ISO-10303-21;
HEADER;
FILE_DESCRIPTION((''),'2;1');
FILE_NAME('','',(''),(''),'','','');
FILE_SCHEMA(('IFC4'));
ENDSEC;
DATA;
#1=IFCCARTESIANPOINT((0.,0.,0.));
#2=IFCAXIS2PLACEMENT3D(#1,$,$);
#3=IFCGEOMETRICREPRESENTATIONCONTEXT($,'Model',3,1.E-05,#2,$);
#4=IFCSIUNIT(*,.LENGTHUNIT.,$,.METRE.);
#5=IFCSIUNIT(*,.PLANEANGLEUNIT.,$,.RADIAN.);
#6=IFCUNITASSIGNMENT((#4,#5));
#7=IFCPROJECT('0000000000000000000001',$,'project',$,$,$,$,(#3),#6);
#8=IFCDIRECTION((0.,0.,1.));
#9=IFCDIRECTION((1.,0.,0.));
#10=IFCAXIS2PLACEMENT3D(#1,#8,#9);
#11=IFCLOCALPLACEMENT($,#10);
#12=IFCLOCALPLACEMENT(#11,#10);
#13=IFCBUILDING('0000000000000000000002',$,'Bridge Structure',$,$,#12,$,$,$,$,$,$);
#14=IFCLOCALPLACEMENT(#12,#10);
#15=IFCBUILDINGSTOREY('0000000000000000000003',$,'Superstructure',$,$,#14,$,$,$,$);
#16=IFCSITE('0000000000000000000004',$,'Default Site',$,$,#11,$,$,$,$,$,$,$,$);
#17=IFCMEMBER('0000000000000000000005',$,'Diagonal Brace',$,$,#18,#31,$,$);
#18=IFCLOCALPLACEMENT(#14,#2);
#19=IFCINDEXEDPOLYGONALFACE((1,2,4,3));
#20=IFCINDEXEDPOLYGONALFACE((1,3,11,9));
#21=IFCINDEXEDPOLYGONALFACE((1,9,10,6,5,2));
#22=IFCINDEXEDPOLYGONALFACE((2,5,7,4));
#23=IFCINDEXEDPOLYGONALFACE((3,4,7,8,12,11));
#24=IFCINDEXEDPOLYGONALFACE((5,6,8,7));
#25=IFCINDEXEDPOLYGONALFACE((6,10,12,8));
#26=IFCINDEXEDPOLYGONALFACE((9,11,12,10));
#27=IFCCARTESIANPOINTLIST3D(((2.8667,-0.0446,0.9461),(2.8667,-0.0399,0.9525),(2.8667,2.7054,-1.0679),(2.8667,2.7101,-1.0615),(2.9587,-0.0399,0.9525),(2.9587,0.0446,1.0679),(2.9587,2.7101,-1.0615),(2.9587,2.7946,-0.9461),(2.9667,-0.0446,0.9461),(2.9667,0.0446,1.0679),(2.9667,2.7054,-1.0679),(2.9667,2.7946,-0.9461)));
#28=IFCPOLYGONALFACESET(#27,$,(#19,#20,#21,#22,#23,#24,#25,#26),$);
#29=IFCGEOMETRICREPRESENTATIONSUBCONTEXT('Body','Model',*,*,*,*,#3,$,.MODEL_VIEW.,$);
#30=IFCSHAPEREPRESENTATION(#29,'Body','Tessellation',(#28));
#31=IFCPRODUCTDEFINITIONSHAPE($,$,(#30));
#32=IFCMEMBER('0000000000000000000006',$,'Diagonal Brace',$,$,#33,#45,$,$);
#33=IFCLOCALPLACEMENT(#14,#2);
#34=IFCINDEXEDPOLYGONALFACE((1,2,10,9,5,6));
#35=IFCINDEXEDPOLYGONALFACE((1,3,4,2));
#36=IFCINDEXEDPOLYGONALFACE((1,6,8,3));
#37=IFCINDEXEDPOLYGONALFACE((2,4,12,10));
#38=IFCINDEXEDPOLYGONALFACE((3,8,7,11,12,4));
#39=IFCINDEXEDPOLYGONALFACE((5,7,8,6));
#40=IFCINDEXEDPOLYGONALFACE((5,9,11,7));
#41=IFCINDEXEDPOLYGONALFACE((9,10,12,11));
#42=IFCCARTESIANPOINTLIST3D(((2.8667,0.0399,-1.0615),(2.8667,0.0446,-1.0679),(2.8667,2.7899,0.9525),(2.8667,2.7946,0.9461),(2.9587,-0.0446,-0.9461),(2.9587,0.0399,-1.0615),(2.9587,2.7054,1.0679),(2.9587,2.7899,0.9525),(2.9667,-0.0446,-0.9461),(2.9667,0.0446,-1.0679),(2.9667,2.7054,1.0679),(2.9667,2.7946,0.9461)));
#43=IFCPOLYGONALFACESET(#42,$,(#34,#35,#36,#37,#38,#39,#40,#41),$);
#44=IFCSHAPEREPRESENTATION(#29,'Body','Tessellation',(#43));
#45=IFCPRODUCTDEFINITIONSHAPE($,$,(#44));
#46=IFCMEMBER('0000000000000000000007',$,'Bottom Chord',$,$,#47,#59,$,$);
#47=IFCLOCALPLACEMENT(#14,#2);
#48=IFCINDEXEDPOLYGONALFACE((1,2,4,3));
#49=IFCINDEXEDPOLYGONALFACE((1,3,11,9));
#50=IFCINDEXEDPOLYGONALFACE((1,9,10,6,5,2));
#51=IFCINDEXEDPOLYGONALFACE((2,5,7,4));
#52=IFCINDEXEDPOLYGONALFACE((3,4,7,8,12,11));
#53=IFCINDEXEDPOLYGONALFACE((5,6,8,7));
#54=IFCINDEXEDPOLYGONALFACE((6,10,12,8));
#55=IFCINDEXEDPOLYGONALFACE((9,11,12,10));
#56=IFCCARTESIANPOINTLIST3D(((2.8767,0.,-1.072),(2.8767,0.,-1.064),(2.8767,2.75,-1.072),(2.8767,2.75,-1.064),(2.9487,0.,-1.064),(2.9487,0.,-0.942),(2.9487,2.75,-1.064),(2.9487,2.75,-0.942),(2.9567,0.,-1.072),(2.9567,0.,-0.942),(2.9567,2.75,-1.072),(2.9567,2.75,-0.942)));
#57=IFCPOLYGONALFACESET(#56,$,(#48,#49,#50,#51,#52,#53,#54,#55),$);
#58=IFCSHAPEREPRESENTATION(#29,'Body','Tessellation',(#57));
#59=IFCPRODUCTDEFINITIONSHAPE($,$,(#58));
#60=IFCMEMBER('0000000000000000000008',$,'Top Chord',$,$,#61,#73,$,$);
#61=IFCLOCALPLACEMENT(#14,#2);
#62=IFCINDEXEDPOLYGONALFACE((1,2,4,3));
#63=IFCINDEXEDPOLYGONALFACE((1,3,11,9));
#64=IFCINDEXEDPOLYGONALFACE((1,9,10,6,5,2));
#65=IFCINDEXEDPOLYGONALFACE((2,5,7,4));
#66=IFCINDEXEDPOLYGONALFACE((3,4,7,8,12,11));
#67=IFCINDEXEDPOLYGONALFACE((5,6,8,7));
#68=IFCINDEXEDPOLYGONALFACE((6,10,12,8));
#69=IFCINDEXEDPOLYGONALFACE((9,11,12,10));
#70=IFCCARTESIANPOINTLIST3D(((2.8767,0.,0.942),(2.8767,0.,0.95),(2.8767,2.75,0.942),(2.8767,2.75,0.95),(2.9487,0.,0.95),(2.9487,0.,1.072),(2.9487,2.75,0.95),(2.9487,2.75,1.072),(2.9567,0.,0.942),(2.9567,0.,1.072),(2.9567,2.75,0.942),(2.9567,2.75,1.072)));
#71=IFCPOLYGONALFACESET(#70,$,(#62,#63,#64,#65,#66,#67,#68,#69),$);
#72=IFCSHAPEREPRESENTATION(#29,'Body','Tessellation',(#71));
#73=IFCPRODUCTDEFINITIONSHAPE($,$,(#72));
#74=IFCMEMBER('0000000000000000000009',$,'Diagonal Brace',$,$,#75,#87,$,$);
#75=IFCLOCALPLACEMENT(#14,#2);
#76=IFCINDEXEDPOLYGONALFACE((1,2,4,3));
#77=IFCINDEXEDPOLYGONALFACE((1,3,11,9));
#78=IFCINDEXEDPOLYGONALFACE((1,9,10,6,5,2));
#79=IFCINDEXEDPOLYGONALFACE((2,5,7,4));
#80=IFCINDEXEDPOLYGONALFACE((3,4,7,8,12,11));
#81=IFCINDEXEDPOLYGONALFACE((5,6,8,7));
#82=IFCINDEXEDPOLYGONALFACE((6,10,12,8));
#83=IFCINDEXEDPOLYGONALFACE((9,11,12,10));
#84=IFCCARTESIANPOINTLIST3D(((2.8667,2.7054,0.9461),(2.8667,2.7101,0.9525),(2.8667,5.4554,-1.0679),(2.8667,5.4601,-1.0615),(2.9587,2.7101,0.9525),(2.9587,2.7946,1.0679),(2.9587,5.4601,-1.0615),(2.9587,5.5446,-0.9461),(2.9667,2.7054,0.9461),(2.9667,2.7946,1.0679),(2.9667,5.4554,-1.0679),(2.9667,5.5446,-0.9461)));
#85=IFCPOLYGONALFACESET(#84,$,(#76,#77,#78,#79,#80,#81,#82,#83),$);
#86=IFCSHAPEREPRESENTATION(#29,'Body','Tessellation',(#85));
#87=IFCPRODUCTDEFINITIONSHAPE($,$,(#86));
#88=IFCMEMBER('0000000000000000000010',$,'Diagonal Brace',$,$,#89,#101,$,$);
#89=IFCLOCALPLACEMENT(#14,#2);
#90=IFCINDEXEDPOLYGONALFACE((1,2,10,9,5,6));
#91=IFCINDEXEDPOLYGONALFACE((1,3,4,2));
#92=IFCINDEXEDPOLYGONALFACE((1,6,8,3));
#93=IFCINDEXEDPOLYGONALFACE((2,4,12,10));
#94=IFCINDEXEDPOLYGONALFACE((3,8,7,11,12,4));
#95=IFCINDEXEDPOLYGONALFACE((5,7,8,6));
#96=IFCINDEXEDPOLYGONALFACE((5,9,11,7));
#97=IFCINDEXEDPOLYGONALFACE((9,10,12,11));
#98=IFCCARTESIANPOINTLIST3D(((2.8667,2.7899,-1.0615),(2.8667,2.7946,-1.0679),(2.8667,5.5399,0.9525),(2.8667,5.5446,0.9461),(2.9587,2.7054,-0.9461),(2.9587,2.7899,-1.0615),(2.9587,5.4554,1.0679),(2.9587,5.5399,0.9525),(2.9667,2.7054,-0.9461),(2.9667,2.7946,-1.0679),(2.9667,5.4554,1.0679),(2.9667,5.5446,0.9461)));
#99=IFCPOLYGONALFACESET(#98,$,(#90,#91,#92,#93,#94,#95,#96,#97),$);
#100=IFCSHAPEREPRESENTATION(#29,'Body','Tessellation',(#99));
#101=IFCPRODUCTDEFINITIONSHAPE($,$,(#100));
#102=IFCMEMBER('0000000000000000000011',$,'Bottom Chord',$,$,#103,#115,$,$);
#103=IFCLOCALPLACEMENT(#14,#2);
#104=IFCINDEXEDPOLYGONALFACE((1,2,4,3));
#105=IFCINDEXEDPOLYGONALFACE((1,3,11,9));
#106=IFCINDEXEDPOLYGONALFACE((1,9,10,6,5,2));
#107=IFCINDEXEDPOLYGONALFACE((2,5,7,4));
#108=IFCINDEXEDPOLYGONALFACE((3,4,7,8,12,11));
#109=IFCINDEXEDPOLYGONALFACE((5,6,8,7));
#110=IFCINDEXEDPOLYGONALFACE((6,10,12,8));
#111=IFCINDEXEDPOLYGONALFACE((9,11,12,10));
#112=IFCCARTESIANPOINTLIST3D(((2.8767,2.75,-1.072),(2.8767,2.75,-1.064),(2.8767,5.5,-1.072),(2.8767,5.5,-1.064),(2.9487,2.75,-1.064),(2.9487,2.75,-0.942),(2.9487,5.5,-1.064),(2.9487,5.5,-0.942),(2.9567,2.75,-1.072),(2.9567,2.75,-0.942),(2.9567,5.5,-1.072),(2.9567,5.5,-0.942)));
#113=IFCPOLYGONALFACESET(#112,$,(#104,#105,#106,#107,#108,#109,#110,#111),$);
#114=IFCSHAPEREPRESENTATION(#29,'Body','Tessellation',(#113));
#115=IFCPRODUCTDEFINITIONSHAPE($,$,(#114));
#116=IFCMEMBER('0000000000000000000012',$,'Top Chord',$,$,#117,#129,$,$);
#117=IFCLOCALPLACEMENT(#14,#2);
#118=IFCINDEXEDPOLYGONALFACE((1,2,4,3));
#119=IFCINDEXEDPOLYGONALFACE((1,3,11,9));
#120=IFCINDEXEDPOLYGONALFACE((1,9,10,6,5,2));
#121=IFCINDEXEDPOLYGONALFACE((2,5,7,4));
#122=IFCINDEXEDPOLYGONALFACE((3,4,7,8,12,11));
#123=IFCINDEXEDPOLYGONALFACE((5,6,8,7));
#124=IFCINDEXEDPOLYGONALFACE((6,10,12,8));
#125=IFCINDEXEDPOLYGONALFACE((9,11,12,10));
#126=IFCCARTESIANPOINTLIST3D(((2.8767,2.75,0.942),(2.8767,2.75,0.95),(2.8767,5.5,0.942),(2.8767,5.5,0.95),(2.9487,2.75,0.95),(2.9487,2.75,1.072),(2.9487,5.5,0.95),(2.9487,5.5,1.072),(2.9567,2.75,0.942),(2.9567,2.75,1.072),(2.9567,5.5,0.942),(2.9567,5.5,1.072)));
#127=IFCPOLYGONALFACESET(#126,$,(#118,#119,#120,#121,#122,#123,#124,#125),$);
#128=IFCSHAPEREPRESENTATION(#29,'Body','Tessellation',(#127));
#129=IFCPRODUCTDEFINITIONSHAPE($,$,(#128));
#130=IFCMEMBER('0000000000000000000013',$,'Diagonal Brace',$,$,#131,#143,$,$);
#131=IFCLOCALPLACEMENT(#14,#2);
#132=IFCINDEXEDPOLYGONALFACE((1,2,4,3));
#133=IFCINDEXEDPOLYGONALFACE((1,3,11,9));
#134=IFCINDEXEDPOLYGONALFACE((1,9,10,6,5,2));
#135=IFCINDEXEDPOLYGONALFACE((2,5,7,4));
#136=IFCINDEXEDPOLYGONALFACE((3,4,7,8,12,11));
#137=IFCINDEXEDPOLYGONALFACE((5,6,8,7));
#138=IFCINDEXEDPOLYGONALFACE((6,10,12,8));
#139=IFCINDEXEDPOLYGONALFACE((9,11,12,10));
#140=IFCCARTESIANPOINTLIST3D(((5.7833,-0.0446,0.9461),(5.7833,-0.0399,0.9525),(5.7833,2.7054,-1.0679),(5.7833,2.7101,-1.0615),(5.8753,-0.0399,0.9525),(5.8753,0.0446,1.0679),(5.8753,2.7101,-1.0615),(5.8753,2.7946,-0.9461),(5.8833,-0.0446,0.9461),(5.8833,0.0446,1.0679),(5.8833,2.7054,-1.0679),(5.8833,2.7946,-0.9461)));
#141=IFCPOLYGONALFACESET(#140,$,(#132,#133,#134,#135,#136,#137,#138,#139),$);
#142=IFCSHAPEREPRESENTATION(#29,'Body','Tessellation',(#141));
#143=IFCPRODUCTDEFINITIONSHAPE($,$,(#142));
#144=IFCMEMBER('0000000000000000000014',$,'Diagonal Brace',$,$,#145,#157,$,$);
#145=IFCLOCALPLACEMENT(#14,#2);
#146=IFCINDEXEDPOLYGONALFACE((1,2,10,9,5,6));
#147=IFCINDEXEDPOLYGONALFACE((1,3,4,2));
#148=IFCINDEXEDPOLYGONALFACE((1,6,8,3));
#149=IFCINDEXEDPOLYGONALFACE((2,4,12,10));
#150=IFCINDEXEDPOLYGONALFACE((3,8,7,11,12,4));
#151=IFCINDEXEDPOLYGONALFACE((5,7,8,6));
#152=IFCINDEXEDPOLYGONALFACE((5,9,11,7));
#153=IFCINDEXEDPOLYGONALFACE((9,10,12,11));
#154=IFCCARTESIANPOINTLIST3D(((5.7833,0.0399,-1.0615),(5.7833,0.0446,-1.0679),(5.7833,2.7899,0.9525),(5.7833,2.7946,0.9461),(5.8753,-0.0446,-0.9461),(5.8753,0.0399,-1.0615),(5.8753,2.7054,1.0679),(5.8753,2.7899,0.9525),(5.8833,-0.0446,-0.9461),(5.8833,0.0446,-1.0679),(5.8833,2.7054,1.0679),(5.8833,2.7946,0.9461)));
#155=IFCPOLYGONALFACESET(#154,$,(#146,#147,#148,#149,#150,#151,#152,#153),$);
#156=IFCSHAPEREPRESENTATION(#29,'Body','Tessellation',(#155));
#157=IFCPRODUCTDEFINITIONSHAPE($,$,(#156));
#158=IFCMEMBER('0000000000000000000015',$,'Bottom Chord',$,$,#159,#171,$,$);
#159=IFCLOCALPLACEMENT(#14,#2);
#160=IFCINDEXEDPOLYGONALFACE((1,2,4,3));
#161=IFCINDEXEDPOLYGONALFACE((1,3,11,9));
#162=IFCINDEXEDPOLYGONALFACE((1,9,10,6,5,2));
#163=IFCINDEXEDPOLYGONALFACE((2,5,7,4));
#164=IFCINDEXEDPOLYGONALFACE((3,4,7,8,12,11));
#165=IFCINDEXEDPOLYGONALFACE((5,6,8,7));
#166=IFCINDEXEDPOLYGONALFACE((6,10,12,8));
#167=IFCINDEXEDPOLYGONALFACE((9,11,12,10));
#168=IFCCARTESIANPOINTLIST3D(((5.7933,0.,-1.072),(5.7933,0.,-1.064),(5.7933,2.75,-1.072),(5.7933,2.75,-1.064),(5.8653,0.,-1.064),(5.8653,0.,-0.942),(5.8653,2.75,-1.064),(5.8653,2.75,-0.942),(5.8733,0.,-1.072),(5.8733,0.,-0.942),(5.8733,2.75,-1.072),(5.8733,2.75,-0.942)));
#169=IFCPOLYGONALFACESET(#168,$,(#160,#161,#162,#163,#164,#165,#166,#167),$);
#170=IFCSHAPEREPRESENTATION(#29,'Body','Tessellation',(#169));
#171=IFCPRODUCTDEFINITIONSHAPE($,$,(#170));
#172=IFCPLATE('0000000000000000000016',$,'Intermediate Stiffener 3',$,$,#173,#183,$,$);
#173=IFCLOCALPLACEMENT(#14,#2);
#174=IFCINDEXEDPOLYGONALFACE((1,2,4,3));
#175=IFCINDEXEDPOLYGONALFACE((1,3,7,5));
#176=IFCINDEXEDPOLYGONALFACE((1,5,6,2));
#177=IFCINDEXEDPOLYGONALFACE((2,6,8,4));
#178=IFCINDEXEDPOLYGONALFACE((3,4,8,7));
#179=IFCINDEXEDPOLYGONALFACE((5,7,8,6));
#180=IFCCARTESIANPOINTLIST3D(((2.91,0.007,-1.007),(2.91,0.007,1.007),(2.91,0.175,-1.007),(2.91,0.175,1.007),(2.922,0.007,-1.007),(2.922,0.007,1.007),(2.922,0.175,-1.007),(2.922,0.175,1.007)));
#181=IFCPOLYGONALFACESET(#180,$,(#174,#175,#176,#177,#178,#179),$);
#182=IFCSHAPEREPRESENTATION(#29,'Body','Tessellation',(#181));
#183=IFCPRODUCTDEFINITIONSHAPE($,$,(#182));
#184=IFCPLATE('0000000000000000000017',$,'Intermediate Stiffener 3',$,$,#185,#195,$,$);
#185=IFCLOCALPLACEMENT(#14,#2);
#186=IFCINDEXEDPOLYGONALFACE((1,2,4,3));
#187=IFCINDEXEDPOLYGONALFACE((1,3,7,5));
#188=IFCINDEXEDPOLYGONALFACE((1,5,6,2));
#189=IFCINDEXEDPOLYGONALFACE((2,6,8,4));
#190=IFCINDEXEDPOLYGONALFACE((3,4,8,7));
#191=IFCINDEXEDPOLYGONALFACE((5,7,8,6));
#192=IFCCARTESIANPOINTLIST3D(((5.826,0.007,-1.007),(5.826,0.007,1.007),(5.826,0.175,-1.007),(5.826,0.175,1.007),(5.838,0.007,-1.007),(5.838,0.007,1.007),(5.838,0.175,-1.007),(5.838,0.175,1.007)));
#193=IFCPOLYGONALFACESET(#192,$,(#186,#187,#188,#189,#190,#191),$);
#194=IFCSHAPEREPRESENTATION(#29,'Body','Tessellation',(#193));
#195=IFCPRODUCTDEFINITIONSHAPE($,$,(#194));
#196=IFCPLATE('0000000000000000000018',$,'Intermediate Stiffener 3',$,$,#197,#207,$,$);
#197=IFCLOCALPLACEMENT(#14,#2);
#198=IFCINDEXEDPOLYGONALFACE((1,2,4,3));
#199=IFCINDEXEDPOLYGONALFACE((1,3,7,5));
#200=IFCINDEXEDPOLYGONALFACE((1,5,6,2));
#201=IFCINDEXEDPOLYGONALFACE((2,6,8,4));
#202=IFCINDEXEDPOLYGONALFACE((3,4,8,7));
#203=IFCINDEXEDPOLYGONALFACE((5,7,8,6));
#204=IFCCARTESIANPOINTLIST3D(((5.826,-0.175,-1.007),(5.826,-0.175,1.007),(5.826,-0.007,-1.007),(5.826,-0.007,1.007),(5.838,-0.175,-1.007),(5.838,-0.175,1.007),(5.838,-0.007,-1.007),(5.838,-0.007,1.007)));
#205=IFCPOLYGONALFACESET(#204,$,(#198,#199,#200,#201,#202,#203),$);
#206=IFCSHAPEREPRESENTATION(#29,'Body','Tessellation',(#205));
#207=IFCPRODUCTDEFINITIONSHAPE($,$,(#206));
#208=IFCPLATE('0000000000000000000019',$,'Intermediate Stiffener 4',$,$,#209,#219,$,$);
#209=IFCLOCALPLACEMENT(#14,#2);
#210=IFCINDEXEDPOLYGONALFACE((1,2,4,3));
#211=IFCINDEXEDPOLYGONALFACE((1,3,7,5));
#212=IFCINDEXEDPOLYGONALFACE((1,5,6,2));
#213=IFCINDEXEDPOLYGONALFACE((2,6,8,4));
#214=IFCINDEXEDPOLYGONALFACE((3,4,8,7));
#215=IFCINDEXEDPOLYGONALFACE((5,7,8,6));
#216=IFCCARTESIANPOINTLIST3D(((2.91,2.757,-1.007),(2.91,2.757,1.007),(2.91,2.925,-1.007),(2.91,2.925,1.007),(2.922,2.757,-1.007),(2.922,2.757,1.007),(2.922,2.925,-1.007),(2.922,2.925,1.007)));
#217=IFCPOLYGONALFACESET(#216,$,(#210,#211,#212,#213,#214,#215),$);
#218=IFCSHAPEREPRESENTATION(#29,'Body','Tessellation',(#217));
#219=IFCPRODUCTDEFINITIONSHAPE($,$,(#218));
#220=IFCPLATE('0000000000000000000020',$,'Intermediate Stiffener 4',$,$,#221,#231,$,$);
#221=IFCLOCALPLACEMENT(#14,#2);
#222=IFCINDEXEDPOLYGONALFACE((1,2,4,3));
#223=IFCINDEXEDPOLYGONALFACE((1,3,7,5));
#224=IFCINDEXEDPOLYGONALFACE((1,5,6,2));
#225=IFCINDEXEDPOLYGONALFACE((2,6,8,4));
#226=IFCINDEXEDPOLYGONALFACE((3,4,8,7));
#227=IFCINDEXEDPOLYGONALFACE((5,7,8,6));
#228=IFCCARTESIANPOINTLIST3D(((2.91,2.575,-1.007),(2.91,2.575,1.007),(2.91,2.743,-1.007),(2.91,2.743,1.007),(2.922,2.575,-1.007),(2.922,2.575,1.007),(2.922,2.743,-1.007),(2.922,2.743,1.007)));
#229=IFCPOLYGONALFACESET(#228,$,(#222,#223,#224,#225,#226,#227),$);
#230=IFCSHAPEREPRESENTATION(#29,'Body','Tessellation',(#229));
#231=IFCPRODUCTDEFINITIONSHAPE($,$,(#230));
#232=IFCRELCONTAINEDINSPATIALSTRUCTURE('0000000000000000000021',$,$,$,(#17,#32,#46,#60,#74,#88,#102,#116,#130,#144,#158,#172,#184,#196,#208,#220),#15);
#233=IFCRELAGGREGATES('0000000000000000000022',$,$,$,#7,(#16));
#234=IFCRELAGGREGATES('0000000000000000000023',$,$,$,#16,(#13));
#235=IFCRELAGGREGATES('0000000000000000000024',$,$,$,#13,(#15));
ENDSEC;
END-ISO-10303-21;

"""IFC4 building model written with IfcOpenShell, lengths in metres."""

from ifc_helpers import new_model, si_unit, frame, origin, origin_with_axes, origin_2d_with_axis, place, context, subcontext, project, spatial, rectangle, l_section, extrude, element, save


model = new_model("IFC4")

# Units and contexts
model_context = context("Model", 3, precision=1e-05, world=origin())
body_context = subcontext(model_context, "Body", "Model", "MODEL_VIEW")
ifc_project = project(units=[si_unit("LENGTHUNIT", "METRE"), si_unit("PLANEANGLEUNIT", "RADIAN")], contexts=[model_context])

# Site, building, storey
site_placement = place(None, origin_with_axes())
site = spatial("IfcSite", under=ifc_project, at=site_placement, Name="Default Site")
building_placement = place(site_placement, origin_with_axes())
building = spatial("IfcBuilding", under=site, at=building_placement, Name="Bridge Structure")
storey_placement = place(building_placement, origin_with_axes())
storey = spatial("IfcBuildingStorey", under=building, at=storey_placement, Name="Superstructure")

# Members
for number, where, z_axis, x_axis, name in (
    (1, (2.9167, 0.0, 1.007), (0.0, 0.806778, -0.590855), (-1.0, 0.0, 0.0), "Diagonal Brace"),
    (2, (2.9167, 0.0, -1.007), (0.0, 0.806778, 0.590855), (-1.0, 0.0, 0.0), "Diagonal Brace"),
):
    element("IfcMember", number, at=place(storey_placement, frame(where, z_axis=z_axis, x_axis=x_axis)), inside=storey, Name=name, context=body_context, shape_type="SweptSolid", body=[
        extrude(l_section(Depth=0.151, Width=0.1, Thickness=0.008, at=origin_2d_with_axis()), origin_with_axes(), (0.0, 0.0, 1.0), 3.4086),
    ])
for number, where, z_axis, x_axis, name in (
    (3, (2.9167, 0.0, -1.007), (0.0, 1.0, 0.0), (-1.0, 0.0, 0.0), "Bottom Chord"),
    (4, (2.9167, 0.0, 1.007), (0.0, 1.0, 0.0), (-1.0, 0.0, 0.0), "Top Chord"),
):
    element("IfcMember", number, at=place(storey_placement, frame(where, z_axis=z_axis, x_axis=x_axis)), inside=storey, Name=name, context=body_context, shape_type="SweptSolid", body=[
        extrude(l_section(Depth=0.13, Width=0.08, Thickness=0.008, at=origin_2d_with_axis()), origin_with_axes(), (0.0, 0.0, 1.0), 2.75),
    ])
for number, where, z_axis, x_axis, name in (
    (5, (2.9167, 2.75, 1.007), (0.0, 0.806778, -0.590855), (-1.0, 0.0, 0.0), "Diagonal Brace"),
    (6, (2.9167, 2.75, -1.007), (0.0, 0.806778, 0.590855), (-1.0, 0.0, 0.0), "Diagonal Brace"),
):
    element("IfcMember", number, at=place(storey_placement, frame(where, z_axis=z_axis, x_axis=x_axis)), inside=storey, Name=name, context=body_context, shape_type="SweptSolid", body=[
        extrude(l_section(Depth=0.151, Width=0.1, Thickness=0.008, at=origin_2d_with_axis()), origin_with_axes(), (0.0, 0.0, 1.0), 3.4086),
    ])
for number, where, z_axis, x_axis, name in (
    (7, (2.9167, 2.75, -1.007), (0.0, 1.0, 0.0), (-1.0, 0.0, 0.0), "Bottom Chord"),
    (8, (2.9167, 2.75, 1.007), (0.0, 1.0, 0.0), (-1.0, 0.0, 0.0), "Top Chord"),
):
    element("IfcMember", number, at=place(storey_placement, frame(where, z_axis=z_axis, x_axis=x_axis)), inside=storey, Name=name, context=body_context, shape_type="SweptSolid", body=[
        extrude(l_section(Depth=0.13, Width=0.08, Thickness=0.008, at=origin_2d_with_axis()), origin_with_axes(), (0.0, 0.0, 1.0), 2.75),
    ])
for number, where, z_axis, x_axis, name in (
    (9, (5.8333, 0.0, 1.007), (0.0, 0.806778, -0.590855), (-1.0, 0.0, 0.0), "Diagonal Brace"),
    (10, (5.8333, 0.0, -1.007), (0.0, 0.806778, 0.590855), (-1.0, 0.0, 0.0), "Diagonal Brace"),
):
    element("IfcMember", number, at=place(storey_placement, frame(where, z_axis=z_axis, x_axis=x_axis)), inside=storey, Name=name, context=body_context, shape_type="SweptSolid", body=[
        extrude(l_section(Depth=0.151, Width=0.1, Thickness=0.008, at=origin_2d_with_axis()), origin_with_axes(), (0.0, 0.0, 1.0), 3.4086),
    ])
member_placement = place(storey_placement, frame((5.8333, 0.0, -1.007), z_axis=(0.0, 1.0, 0.0), x_axis=(-1.0, 0.0, 0.0)))
element("IfcMember", 11, at=member_placement, inside=storey, Name="Bottom Chord", context=body_context, shape_type="SweptSolid", body=[
    extrude(l_section(Depth=0.13, Width=0.08, Thickness=0.008, at=origin_2d_with_axis()), origin_with_axes(), (0.0, 0.0, 1.0), 2.75),
])

# Plates
for number, where, z_axis, x_axis, name in (
    (12, (2.916, 0.091, -1.007), (0.0, 0.0, 1.0), (1.0, 0.0, 0.0), "Intermediate Stiffener 3"),
    (13, (5.832, 0.091, -1.007), (0.0, 0.0, 1.0), (1.0, 0.0, 0.0), "Intermediate Stiffener 3"),
    (14, (5.832, -0.091, -1.007), (0.0, 0.0, 1.0), (1.0, 0.0, 0.0), "Intermediate Stiffener 3"),
    (15, (2.916, 2.841, -1.007), (0.0, 0.0, 1.0), (1.0, 0.0, 0.0), "Intermediate Stiffener 4"),
    (16, (2.916, 2.659, -1.007), (0.0, 0.0, 1.0), (1.0, 0.0, 0.0), "Intermediate Stiffener 4"),
):
    element("IfcPlate", number, at=place(storey_placement, frame(where, z_axis=z_axis, x_axis=x_axis)), inside=storey, Name=name, context=body_context, shape_type="SweptSolid", body=[
        extrude(rectangle(XDim=0.012, YDim=0.168, at=origin_2d_with_axis()), origin_with_axes(), (0.0, 0.0, 1.0), 2.014),
    ])

save(model, "model.ifc")
